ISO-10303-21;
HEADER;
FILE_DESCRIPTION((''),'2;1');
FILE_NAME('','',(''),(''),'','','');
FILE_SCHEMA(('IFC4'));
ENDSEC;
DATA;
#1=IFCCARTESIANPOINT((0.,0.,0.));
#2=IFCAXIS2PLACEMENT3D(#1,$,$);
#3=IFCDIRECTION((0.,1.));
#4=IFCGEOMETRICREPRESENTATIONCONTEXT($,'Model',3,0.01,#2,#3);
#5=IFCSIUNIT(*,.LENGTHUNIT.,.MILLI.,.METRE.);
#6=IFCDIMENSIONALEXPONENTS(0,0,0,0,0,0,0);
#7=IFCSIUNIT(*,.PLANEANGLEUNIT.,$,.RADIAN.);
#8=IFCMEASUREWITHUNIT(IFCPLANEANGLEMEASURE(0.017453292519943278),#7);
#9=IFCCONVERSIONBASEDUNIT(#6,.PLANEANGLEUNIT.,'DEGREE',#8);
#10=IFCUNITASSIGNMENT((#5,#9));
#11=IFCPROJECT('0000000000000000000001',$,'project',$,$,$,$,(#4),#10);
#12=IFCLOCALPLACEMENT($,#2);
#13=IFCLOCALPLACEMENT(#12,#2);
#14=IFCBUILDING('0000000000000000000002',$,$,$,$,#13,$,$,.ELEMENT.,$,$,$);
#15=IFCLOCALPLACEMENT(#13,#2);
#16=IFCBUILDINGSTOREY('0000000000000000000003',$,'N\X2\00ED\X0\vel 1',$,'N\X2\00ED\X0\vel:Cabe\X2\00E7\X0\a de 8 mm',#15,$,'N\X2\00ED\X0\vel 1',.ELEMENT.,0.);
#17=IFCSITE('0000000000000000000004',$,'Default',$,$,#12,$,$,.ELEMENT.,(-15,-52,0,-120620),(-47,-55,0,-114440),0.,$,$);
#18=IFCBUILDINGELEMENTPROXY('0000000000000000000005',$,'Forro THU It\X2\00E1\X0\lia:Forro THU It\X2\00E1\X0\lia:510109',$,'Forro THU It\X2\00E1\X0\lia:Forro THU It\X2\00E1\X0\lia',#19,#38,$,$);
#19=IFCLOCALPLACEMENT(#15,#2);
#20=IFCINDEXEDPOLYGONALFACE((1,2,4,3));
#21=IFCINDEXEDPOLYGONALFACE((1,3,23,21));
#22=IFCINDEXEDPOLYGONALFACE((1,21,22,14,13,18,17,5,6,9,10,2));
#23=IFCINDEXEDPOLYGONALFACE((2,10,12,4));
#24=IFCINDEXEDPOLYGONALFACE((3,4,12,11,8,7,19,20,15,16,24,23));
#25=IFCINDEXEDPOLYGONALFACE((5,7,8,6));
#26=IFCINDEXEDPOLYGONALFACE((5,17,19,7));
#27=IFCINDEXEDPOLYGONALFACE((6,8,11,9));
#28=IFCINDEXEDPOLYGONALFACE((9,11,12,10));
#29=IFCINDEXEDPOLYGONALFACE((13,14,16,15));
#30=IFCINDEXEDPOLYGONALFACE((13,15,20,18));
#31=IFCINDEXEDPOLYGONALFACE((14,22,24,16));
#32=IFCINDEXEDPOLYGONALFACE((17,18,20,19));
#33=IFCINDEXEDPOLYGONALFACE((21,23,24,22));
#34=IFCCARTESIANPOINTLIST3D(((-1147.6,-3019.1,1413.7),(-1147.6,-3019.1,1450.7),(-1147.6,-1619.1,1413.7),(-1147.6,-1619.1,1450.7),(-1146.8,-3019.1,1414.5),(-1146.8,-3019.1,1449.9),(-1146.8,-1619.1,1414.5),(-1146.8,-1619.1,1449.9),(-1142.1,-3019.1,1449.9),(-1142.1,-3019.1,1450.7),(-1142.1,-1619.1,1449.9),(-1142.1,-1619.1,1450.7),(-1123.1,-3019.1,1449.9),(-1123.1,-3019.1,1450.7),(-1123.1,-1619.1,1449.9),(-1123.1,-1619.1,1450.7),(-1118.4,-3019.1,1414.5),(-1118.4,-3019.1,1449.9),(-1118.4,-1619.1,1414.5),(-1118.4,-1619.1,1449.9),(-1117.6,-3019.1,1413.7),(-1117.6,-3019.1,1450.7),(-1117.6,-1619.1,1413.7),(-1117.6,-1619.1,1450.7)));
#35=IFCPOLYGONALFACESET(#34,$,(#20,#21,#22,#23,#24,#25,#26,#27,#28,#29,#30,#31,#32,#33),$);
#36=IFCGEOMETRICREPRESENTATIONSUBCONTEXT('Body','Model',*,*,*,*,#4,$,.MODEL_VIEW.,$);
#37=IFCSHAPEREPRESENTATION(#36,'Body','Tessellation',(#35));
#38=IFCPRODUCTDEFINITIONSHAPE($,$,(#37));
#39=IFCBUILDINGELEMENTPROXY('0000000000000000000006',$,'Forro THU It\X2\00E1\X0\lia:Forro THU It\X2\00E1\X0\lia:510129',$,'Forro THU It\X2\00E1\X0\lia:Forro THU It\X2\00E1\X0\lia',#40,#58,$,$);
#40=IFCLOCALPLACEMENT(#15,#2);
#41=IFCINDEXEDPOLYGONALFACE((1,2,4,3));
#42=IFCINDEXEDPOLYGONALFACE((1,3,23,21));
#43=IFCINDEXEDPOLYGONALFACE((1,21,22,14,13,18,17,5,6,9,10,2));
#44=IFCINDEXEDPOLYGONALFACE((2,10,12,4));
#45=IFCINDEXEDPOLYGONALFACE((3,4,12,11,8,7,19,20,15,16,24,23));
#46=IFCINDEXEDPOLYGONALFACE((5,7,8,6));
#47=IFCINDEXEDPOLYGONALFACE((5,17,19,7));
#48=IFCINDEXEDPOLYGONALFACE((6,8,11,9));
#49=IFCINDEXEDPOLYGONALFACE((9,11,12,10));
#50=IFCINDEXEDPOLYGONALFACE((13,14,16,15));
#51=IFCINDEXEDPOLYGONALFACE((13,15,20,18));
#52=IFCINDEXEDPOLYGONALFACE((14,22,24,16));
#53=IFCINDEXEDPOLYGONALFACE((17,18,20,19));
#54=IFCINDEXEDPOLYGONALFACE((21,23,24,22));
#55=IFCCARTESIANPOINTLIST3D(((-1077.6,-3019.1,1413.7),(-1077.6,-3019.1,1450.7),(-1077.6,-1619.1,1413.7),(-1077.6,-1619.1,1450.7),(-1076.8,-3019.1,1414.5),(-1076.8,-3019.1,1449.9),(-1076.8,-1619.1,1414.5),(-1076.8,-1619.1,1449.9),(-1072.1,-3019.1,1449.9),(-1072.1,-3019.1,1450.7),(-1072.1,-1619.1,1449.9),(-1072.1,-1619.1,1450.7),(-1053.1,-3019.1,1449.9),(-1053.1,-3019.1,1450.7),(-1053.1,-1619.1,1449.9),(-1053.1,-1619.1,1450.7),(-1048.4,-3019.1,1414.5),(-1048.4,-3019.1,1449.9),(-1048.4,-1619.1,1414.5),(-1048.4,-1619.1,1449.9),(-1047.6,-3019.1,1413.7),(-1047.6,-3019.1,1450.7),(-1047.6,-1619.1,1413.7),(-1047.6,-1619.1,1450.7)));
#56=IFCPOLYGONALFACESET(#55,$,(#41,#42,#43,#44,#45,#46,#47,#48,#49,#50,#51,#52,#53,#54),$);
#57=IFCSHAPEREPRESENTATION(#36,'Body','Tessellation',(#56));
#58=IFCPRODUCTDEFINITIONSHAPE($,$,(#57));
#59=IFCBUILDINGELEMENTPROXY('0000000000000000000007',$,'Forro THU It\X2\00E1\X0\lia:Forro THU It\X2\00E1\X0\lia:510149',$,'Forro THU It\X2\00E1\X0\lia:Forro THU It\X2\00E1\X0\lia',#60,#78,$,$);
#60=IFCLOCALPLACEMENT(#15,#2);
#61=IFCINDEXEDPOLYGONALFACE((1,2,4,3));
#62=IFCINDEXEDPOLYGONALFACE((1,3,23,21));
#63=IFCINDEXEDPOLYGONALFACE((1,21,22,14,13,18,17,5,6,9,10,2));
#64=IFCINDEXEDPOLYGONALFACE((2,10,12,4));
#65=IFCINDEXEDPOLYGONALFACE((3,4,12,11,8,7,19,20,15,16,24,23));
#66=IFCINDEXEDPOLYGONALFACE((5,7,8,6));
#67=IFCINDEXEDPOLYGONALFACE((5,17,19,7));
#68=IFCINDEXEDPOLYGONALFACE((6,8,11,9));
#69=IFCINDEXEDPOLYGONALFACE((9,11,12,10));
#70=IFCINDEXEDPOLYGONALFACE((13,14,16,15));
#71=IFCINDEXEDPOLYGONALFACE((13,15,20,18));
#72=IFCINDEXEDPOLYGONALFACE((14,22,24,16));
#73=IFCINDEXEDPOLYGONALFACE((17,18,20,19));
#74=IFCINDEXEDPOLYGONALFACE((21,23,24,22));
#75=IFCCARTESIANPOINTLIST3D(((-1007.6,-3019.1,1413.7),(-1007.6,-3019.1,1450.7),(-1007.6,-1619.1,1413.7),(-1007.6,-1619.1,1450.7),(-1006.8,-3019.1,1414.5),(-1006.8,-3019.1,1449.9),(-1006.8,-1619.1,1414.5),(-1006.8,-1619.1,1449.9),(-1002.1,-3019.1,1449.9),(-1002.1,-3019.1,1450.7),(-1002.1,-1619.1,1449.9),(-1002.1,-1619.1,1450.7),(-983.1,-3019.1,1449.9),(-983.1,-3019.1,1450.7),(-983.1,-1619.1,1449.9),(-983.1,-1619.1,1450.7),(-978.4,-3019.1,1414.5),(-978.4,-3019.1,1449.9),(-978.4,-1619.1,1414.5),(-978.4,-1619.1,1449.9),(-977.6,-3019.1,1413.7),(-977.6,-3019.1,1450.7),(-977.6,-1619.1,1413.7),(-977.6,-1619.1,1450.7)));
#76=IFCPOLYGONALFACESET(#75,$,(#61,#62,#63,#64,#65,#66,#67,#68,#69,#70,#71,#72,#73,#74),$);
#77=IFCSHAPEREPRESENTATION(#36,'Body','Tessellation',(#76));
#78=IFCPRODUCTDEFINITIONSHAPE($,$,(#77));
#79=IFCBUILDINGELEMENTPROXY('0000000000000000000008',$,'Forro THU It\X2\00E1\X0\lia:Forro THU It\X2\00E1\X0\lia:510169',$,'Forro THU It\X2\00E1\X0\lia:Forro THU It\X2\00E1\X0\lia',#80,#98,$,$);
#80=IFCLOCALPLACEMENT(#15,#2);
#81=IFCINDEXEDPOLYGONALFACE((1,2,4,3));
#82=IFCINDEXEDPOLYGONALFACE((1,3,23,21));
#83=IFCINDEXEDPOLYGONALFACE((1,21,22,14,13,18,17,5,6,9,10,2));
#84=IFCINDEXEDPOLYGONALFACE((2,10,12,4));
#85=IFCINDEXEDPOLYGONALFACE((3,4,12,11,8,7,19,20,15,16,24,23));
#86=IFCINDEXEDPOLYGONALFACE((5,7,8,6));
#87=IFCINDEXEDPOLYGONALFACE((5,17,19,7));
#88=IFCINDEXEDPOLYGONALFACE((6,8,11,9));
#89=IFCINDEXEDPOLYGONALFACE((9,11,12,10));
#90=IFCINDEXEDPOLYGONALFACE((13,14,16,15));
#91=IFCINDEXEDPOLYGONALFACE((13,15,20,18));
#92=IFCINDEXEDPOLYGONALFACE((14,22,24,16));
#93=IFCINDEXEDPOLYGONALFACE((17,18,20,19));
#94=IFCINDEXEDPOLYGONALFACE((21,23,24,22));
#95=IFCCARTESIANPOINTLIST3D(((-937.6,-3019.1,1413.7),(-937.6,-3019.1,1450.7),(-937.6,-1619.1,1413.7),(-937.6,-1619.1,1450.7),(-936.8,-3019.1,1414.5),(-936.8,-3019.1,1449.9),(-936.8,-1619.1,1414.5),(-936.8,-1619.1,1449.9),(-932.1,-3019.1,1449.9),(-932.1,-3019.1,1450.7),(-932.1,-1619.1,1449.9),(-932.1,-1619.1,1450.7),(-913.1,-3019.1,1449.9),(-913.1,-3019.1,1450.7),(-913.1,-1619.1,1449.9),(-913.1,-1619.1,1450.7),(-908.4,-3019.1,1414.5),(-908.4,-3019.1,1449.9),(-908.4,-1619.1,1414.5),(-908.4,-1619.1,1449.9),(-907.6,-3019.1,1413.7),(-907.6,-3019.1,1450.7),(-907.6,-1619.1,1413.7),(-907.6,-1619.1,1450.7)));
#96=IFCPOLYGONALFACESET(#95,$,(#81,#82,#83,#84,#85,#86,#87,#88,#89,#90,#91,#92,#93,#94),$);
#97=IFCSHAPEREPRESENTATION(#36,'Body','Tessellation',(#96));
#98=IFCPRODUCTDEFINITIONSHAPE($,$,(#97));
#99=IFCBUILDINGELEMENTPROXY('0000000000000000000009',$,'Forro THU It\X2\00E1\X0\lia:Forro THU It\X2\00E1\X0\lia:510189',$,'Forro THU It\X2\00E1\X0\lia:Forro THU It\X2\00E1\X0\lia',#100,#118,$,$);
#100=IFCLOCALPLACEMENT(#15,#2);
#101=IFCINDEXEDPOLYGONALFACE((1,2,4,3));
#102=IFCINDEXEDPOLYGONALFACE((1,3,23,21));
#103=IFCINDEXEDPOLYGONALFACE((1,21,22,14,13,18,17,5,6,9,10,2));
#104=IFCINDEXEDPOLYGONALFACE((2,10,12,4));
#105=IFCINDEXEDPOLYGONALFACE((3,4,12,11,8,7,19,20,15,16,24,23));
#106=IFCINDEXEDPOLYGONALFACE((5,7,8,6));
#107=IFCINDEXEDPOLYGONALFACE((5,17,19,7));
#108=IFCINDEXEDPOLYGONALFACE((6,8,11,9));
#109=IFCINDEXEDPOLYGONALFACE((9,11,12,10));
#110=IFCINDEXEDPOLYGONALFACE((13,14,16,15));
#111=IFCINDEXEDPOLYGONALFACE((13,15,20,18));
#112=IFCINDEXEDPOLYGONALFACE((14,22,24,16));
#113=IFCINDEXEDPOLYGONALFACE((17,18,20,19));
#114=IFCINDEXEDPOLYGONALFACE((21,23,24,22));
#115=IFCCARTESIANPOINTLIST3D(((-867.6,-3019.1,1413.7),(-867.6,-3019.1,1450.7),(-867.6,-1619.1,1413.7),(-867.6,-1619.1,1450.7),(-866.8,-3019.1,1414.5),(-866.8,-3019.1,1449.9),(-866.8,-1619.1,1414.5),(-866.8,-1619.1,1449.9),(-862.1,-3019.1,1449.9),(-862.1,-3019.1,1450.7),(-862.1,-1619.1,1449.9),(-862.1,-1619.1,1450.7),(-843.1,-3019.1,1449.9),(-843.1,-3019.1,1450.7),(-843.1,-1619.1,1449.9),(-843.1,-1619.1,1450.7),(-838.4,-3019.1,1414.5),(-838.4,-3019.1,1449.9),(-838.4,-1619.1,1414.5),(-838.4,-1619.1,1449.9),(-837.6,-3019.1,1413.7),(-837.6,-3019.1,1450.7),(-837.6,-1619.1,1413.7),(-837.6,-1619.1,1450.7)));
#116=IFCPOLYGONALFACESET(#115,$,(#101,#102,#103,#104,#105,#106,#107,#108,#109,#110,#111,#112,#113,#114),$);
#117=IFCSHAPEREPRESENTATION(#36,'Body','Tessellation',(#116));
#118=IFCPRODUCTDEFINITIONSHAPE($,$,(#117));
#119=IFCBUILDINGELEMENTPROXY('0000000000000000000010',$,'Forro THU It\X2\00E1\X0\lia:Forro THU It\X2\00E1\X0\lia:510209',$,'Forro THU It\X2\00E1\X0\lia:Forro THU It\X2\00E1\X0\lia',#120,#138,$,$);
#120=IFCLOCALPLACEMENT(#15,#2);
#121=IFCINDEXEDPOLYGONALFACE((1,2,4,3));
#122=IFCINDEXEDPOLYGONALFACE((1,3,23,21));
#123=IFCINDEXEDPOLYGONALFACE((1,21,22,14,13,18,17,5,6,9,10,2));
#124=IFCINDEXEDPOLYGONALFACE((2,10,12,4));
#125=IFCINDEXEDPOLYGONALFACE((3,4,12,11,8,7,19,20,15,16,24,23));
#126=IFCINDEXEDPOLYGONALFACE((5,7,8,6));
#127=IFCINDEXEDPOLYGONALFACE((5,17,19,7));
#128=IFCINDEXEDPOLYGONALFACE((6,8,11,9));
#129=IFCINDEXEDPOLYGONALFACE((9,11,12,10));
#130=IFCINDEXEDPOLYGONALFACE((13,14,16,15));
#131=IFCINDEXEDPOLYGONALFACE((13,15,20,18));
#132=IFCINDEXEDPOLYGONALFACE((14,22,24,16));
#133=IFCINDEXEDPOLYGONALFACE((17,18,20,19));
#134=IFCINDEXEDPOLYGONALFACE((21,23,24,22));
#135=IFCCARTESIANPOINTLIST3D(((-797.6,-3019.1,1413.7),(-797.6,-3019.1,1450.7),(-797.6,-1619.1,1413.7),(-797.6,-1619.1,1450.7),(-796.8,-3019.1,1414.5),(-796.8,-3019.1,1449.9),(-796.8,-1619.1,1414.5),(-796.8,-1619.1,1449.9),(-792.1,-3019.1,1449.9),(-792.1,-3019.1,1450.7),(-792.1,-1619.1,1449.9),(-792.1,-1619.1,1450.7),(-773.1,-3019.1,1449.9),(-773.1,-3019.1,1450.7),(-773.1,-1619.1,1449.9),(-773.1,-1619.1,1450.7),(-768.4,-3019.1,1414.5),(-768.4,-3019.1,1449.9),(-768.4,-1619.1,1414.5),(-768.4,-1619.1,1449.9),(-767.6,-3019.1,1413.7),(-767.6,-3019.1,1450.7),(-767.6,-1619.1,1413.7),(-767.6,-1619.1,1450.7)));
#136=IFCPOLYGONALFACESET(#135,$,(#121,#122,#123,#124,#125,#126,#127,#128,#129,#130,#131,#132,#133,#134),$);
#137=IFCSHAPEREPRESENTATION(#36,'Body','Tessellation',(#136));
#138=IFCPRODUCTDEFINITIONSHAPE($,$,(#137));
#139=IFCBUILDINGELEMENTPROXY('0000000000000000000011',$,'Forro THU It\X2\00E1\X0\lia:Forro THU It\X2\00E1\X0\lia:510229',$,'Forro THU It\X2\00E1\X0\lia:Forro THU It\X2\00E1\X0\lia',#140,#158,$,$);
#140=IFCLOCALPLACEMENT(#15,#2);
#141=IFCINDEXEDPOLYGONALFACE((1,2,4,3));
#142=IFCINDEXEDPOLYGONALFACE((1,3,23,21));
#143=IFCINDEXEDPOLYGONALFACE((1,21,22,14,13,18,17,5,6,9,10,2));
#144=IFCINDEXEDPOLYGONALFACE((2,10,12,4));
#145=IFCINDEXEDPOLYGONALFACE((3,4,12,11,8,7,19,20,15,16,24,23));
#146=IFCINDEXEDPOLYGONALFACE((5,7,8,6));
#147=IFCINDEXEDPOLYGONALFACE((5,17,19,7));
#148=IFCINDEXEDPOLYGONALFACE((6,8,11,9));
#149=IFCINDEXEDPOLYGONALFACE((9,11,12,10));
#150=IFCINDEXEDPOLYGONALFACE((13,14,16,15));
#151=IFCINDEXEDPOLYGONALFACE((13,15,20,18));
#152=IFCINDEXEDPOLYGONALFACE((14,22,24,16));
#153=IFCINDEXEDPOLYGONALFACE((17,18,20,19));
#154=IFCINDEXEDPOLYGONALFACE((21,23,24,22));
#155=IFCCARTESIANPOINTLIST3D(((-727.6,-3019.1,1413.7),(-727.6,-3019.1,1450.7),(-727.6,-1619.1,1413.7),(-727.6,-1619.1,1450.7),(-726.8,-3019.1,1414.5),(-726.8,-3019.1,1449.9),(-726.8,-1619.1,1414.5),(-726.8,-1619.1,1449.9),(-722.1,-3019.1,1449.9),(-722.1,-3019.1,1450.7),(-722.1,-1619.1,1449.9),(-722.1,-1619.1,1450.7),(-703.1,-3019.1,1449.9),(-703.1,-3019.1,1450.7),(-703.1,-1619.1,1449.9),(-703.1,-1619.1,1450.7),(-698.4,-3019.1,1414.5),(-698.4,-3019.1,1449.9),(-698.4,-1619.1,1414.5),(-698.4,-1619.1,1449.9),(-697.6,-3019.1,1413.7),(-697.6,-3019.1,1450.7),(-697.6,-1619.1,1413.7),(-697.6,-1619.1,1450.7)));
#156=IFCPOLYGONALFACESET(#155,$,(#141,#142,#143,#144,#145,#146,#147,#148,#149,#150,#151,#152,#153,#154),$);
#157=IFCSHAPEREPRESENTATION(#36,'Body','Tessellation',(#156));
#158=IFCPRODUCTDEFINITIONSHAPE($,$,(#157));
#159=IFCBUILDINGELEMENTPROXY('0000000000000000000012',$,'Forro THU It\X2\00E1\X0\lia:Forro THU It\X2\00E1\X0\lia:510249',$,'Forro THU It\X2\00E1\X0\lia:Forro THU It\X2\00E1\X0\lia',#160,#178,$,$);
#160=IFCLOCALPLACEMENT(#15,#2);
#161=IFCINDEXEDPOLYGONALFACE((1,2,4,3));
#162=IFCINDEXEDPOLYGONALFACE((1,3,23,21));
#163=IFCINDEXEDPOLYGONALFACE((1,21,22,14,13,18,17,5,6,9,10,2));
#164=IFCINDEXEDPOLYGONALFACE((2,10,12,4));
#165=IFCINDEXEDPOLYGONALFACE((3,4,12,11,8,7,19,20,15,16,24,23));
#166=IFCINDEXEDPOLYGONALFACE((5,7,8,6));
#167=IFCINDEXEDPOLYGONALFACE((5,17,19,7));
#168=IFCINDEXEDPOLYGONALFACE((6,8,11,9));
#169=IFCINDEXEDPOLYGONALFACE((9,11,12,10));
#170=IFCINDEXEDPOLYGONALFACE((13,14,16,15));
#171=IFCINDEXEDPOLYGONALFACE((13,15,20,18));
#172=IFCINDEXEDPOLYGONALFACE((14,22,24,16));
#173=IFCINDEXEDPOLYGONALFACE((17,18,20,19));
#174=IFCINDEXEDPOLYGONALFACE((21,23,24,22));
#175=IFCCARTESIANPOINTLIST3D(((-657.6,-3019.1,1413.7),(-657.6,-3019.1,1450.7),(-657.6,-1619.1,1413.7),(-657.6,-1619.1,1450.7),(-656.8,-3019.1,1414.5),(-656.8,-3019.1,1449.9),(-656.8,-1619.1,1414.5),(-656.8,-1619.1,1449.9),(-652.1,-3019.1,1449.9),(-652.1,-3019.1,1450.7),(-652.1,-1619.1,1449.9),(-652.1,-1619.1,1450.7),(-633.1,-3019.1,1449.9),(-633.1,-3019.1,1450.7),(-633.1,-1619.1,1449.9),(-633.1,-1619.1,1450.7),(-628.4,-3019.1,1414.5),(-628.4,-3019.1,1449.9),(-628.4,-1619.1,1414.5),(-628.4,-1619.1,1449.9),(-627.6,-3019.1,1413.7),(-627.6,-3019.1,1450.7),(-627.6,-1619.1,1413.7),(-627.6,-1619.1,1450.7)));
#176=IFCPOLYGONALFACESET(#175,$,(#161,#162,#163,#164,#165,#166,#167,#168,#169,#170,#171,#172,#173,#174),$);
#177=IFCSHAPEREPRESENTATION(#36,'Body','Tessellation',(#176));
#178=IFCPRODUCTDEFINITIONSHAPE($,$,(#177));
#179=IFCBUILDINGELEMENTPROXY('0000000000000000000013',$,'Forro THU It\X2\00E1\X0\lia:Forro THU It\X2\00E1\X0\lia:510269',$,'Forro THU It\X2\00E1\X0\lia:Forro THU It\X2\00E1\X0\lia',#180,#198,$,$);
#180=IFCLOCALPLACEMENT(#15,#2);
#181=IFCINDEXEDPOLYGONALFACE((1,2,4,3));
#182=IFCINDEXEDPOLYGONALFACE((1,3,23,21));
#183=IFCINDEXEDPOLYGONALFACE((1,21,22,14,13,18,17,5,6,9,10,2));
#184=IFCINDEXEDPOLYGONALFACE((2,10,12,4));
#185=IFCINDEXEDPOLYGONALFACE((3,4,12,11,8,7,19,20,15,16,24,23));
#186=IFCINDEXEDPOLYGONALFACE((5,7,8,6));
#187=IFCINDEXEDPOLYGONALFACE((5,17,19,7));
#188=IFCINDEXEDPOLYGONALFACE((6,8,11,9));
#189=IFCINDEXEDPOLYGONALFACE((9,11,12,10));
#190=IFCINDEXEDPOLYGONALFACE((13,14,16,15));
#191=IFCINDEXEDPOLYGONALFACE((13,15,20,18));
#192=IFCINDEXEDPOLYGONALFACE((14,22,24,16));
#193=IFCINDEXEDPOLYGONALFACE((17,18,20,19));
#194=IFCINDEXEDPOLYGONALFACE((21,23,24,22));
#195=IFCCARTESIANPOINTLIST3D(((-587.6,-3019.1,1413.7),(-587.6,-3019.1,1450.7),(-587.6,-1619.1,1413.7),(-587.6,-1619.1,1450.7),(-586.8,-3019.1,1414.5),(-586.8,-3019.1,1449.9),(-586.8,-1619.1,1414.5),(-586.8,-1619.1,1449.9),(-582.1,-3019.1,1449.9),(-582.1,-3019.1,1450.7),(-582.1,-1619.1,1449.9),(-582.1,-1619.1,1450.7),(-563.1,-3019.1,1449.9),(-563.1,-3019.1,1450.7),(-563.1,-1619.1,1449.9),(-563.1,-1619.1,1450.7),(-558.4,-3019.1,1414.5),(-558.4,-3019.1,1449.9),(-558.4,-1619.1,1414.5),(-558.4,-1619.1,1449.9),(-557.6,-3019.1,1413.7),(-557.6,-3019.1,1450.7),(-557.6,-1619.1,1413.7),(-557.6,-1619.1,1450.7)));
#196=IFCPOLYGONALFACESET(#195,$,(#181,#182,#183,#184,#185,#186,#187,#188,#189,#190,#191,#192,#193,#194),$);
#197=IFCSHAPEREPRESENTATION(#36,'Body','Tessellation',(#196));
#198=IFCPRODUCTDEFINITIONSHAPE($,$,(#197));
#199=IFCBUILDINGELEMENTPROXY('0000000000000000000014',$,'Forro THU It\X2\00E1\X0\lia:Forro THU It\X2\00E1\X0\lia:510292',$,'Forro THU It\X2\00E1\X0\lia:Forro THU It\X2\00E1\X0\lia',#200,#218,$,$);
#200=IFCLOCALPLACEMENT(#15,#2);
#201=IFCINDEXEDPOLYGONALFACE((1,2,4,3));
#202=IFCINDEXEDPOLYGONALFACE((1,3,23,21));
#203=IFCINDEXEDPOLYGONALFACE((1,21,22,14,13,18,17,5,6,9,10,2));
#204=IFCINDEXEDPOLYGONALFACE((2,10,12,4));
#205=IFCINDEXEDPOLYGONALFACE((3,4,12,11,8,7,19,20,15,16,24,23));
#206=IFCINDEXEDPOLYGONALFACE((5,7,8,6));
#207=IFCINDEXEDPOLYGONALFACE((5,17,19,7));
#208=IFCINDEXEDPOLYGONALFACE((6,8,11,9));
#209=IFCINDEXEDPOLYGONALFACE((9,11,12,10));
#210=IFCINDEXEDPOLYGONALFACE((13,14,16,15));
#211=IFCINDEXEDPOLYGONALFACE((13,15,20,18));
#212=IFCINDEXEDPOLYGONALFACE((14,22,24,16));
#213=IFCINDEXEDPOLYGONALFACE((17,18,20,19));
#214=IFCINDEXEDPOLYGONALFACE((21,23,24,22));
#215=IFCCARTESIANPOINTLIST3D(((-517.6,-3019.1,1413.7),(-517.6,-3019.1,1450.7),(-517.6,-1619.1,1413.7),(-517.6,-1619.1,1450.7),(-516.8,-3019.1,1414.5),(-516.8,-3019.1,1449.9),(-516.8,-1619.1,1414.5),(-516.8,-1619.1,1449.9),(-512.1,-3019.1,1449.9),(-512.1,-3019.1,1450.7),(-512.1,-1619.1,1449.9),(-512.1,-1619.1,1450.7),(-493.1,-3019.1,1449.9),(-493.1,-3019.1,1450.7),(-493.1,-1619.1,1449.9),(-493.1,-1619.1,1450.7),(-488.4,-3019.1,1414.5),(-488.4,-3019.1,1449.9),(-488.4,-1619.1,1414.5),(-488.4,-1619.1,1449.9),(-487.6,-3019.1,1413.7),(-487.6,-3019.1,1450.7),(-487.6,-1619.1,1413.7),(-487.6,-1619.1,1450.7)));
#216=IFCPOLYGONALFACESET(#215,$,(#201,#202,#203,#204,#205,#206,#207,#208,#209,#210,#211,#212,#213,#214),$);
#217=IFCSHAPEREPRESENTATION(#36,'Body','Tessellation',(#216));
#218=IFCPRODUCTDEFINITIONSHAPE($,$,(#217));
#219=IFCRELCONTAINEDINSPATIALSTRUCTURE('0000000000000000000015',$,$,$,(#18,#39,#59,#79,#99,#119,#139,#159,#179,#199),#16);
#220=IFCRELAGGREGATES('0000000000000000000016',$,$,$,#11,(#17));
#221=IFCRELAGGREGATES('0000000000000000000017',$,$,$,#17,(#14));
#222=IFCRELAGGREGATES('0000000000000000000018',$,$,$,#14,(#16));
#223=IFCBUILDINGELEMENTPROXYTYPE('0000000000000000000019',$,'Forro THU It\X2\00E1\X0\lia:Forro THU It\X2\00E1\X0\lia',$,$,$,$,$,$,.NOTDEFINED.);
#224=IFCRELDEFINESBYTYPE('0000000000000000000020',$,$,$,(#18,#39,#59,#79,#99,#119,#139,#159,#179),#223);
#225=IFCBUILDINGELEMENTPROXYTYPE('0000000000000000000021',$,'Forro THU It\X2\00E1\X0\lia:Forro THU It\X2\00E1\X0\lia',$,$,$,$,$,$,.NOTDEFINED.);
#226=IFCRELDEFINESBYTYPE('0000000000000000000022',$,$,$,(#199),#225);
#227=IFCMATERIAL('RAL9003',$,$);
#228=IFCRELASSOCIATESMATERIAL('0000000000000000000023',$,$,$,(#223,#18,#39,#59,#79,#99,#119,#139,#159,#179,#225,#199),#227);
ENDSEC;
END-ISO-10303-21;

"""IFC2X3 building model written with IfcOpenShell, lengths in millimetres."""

from ifc_helpers import new_model, entity, si_unit, converted_unit, direction, frame, origin, place, context, subcontext, project, spatial, polyline, outline, extrude, source, transform, mapped, material, type_object, type_shapes, element, save


model = new_model("IFC2X3")

# Units and contexts
model_context = context("Model", 3, precision=0.01, world=origin(), true_north=direction((0.0, 1.0)))
body_context = subcontext(model_context, "Body", "Model", "MODEL_VIEW")
ifc_project = project(units=[si_unit("LENGTHUNIT", "METRE", prefix="MILLI"), converted_unit("PLANEANGLEUNIT", "DEGREE", entity("IfcPlaneAngleMeasure", 0.017453292519943278), si_unit("PLANEANGLEUNIT", "RADIAN"), dimensions=[0, 0, 0, 0, 0, 0, 0])], contexts=[model_context])

# Site, building, storey
site_placement = place(None, origin())
site = spatial("IfcSite", under=ifc_project, at=site_placement, Name="Default", CompositionType="ELEMENT", RefLatitude=(-15, -52, 0, -120620), RefLongitude=(-47, -55, 0, -114440), RefElevation=0.0)
building_placement = place(site_placement, origin())
building = spatial("IfcBuilding", under=site, at=building_placement, CompositionType="ELEMENT")
storey_placement = place(building_placement, origin())
storey = spatial("IfcBuildingStorey", under=building, at=storey_placement, Name="Nível 1", ObjectType="Nível:Cabeça de 8 mm", LongName="Nível 1", CompositionType="ELEMENT", Elevation=0.0)

# Building element proxies
ifc_material = material(Name="RAL9003")
building_element_proxy_type_1 = type_object("IfcBuildingElementProxyType", Name="Forro THU Itália:Forro THU Itália", PredefinedType="NOTDEFINED", material=ifc_material)
shared_shape_1 = source(origin(), body_context, "Body", "SweptSolid", [
    extrude(outline(polyline([(-15.0, -12.5), (-9.5, -12.5), (-9.5, -11.7), (-14.2, -11.7), (-14.2, 23.7), (14.2, 23.7), (14.2, -11.7), (9.5, -11.7), (9.5, -12.5), (15.0, -12.5), (15.0, 24.5), (-15.0, 24.5), (-15.0, -12.5)])), frame((0.0, -15.0, -12.5), z_axis=(1.0, 0.0, 0.0), x_axis=(0.0, -1.0, 0.0)), (0.0, 0.0, 1.0), 1400.0),
])
type_shapes(building_element_proxy_type_1, [shared_shape_1])
for number, where, z_axis, x_axis, name in (
    (1, (-1147.6, -3019.1, 1450.7), (0.0, 0.0, 1.0), (0.0, 1.0, 0.0), "Forro THU Itália:Forro THU Itália:510109"),
    (2, (-1077.6, -3019.1, 1450.7), (0.0, 0.0, 1.0), (0.0, 1.0, 0.0), "Forro THU Itália:Forro THU Itália:510129"),
    (3, (-1007.6, -3019.1, 1450.7), (0.0, 0.0, 1.0), (0.0, 1.0, 0.0), "Forro THU Itália:Forro THU Itália:510149"),
    (4, (-937.6, -3019.1, 1450.7), (0.0, 0.0, 1.0), (0.0, 1.0, 0.0), "Forro THU Itália:Forro THU Itália:510169"),
    (5, (-867.6, -3019.1, 1450.7), (0.0, 0.0, 1.0), (0.0, 1.0, 0.0), "Forro THU Itália:Forro THU Itália:510189"),
    (6, (-797.6, -3019.1, 1450.7), (0.0, 0.0, 1.0), (0.0, 1.0, 0.0), "Forro THU Itália:Forro THU Itália:510209"),
    (7, (-727.6, -3019.1, 1450.7), (0.0, 0.0, 1.0), (0.0, 1.0, 0.0), "Forro THU Itália:Forro THU Itália:510229"),
    (8, (-657.6, -3019.1, 1450.7), (0.0, 0.0, 1.0), (0.0, 1.0, 0.0), "Forro THU Itália:Forro THU Itália:510249"),
    (9, (-587.6, -3019.1, 1450.7), (0.0, 0.0, 1.0), (0.0, 1.0, 0.0), "Forro THU Itália:Forro THU Itália:510269"),
):
    element("IfcBuildingElementProxy", number, at=place(storey_placement, frame(where, z_axis=z_axis, x_axis=x_axis)), inside=storey, type_object=building_element_proxy_type_1, material=ifc_material, Name=name, ObjectType="Forro THU Itália:Forro THU Itália", context=body_context, shape_type="MappedRepresentation", body=[
        mapped(shared_shape_1, transform((0.0, 0.0, 0.0), scale=1.0)),
    ])
building_element_proxy_type_2 = type_object("IfcBuildingElementProxyType", Name="Forro THU Itália:Forro THU Itália", PredefinedType="NOTDEFINED", material=ifc_material)
shared_shape_2 = source(origin(), body_context, "Body", "SweptSolid", [
    extrude(outline(polyline([(-15.0, -12.5), (-9.5, -12.5), (-9.5, -11.7), (-14.2, -11.7), (-14.2, 23.7), (14.2, 23.7), (14.2, -11.7), (9.5, -11.7), (9.5, -12.5), (15.0, -12.5), (15.0, 24.5), (-15.0, 24.5), (-15.0, -12.5)])), frame((0.0, -15.0, -12.5), z_axis=(1.0, 0.0, 0.0), x_axis=(0.0, -1.0, 0.0)), (0.0, 0.0, 1.0), 1400.0),
])
type_shapes(building_element_proxy_type_2, [shared_shape_2])
proxy_placement = place(storey_placement, frame((-517.6, -3019.1, 1450.7), z_axis=(0.0, 0.0, 1.0), x_axis=(0.0, 1.0, 0.0)))
element("IfcBuildingElementProxy", 10, at=proxy_placement, inside=storey, type_object=building_element_proxy_type_2, material=ifc_material, Name="Forro THU Itália:Forro THU Itália:510292", ObjectType="Forro THU Itália:Forro THU Itália", context=body_context, shape_type="MappedRepresentation", body=[
    mapped(shared_shape_2, transform((0.0, 0.0, 0.0), scale=1.0)),
])

save(model, "model.ifc")
